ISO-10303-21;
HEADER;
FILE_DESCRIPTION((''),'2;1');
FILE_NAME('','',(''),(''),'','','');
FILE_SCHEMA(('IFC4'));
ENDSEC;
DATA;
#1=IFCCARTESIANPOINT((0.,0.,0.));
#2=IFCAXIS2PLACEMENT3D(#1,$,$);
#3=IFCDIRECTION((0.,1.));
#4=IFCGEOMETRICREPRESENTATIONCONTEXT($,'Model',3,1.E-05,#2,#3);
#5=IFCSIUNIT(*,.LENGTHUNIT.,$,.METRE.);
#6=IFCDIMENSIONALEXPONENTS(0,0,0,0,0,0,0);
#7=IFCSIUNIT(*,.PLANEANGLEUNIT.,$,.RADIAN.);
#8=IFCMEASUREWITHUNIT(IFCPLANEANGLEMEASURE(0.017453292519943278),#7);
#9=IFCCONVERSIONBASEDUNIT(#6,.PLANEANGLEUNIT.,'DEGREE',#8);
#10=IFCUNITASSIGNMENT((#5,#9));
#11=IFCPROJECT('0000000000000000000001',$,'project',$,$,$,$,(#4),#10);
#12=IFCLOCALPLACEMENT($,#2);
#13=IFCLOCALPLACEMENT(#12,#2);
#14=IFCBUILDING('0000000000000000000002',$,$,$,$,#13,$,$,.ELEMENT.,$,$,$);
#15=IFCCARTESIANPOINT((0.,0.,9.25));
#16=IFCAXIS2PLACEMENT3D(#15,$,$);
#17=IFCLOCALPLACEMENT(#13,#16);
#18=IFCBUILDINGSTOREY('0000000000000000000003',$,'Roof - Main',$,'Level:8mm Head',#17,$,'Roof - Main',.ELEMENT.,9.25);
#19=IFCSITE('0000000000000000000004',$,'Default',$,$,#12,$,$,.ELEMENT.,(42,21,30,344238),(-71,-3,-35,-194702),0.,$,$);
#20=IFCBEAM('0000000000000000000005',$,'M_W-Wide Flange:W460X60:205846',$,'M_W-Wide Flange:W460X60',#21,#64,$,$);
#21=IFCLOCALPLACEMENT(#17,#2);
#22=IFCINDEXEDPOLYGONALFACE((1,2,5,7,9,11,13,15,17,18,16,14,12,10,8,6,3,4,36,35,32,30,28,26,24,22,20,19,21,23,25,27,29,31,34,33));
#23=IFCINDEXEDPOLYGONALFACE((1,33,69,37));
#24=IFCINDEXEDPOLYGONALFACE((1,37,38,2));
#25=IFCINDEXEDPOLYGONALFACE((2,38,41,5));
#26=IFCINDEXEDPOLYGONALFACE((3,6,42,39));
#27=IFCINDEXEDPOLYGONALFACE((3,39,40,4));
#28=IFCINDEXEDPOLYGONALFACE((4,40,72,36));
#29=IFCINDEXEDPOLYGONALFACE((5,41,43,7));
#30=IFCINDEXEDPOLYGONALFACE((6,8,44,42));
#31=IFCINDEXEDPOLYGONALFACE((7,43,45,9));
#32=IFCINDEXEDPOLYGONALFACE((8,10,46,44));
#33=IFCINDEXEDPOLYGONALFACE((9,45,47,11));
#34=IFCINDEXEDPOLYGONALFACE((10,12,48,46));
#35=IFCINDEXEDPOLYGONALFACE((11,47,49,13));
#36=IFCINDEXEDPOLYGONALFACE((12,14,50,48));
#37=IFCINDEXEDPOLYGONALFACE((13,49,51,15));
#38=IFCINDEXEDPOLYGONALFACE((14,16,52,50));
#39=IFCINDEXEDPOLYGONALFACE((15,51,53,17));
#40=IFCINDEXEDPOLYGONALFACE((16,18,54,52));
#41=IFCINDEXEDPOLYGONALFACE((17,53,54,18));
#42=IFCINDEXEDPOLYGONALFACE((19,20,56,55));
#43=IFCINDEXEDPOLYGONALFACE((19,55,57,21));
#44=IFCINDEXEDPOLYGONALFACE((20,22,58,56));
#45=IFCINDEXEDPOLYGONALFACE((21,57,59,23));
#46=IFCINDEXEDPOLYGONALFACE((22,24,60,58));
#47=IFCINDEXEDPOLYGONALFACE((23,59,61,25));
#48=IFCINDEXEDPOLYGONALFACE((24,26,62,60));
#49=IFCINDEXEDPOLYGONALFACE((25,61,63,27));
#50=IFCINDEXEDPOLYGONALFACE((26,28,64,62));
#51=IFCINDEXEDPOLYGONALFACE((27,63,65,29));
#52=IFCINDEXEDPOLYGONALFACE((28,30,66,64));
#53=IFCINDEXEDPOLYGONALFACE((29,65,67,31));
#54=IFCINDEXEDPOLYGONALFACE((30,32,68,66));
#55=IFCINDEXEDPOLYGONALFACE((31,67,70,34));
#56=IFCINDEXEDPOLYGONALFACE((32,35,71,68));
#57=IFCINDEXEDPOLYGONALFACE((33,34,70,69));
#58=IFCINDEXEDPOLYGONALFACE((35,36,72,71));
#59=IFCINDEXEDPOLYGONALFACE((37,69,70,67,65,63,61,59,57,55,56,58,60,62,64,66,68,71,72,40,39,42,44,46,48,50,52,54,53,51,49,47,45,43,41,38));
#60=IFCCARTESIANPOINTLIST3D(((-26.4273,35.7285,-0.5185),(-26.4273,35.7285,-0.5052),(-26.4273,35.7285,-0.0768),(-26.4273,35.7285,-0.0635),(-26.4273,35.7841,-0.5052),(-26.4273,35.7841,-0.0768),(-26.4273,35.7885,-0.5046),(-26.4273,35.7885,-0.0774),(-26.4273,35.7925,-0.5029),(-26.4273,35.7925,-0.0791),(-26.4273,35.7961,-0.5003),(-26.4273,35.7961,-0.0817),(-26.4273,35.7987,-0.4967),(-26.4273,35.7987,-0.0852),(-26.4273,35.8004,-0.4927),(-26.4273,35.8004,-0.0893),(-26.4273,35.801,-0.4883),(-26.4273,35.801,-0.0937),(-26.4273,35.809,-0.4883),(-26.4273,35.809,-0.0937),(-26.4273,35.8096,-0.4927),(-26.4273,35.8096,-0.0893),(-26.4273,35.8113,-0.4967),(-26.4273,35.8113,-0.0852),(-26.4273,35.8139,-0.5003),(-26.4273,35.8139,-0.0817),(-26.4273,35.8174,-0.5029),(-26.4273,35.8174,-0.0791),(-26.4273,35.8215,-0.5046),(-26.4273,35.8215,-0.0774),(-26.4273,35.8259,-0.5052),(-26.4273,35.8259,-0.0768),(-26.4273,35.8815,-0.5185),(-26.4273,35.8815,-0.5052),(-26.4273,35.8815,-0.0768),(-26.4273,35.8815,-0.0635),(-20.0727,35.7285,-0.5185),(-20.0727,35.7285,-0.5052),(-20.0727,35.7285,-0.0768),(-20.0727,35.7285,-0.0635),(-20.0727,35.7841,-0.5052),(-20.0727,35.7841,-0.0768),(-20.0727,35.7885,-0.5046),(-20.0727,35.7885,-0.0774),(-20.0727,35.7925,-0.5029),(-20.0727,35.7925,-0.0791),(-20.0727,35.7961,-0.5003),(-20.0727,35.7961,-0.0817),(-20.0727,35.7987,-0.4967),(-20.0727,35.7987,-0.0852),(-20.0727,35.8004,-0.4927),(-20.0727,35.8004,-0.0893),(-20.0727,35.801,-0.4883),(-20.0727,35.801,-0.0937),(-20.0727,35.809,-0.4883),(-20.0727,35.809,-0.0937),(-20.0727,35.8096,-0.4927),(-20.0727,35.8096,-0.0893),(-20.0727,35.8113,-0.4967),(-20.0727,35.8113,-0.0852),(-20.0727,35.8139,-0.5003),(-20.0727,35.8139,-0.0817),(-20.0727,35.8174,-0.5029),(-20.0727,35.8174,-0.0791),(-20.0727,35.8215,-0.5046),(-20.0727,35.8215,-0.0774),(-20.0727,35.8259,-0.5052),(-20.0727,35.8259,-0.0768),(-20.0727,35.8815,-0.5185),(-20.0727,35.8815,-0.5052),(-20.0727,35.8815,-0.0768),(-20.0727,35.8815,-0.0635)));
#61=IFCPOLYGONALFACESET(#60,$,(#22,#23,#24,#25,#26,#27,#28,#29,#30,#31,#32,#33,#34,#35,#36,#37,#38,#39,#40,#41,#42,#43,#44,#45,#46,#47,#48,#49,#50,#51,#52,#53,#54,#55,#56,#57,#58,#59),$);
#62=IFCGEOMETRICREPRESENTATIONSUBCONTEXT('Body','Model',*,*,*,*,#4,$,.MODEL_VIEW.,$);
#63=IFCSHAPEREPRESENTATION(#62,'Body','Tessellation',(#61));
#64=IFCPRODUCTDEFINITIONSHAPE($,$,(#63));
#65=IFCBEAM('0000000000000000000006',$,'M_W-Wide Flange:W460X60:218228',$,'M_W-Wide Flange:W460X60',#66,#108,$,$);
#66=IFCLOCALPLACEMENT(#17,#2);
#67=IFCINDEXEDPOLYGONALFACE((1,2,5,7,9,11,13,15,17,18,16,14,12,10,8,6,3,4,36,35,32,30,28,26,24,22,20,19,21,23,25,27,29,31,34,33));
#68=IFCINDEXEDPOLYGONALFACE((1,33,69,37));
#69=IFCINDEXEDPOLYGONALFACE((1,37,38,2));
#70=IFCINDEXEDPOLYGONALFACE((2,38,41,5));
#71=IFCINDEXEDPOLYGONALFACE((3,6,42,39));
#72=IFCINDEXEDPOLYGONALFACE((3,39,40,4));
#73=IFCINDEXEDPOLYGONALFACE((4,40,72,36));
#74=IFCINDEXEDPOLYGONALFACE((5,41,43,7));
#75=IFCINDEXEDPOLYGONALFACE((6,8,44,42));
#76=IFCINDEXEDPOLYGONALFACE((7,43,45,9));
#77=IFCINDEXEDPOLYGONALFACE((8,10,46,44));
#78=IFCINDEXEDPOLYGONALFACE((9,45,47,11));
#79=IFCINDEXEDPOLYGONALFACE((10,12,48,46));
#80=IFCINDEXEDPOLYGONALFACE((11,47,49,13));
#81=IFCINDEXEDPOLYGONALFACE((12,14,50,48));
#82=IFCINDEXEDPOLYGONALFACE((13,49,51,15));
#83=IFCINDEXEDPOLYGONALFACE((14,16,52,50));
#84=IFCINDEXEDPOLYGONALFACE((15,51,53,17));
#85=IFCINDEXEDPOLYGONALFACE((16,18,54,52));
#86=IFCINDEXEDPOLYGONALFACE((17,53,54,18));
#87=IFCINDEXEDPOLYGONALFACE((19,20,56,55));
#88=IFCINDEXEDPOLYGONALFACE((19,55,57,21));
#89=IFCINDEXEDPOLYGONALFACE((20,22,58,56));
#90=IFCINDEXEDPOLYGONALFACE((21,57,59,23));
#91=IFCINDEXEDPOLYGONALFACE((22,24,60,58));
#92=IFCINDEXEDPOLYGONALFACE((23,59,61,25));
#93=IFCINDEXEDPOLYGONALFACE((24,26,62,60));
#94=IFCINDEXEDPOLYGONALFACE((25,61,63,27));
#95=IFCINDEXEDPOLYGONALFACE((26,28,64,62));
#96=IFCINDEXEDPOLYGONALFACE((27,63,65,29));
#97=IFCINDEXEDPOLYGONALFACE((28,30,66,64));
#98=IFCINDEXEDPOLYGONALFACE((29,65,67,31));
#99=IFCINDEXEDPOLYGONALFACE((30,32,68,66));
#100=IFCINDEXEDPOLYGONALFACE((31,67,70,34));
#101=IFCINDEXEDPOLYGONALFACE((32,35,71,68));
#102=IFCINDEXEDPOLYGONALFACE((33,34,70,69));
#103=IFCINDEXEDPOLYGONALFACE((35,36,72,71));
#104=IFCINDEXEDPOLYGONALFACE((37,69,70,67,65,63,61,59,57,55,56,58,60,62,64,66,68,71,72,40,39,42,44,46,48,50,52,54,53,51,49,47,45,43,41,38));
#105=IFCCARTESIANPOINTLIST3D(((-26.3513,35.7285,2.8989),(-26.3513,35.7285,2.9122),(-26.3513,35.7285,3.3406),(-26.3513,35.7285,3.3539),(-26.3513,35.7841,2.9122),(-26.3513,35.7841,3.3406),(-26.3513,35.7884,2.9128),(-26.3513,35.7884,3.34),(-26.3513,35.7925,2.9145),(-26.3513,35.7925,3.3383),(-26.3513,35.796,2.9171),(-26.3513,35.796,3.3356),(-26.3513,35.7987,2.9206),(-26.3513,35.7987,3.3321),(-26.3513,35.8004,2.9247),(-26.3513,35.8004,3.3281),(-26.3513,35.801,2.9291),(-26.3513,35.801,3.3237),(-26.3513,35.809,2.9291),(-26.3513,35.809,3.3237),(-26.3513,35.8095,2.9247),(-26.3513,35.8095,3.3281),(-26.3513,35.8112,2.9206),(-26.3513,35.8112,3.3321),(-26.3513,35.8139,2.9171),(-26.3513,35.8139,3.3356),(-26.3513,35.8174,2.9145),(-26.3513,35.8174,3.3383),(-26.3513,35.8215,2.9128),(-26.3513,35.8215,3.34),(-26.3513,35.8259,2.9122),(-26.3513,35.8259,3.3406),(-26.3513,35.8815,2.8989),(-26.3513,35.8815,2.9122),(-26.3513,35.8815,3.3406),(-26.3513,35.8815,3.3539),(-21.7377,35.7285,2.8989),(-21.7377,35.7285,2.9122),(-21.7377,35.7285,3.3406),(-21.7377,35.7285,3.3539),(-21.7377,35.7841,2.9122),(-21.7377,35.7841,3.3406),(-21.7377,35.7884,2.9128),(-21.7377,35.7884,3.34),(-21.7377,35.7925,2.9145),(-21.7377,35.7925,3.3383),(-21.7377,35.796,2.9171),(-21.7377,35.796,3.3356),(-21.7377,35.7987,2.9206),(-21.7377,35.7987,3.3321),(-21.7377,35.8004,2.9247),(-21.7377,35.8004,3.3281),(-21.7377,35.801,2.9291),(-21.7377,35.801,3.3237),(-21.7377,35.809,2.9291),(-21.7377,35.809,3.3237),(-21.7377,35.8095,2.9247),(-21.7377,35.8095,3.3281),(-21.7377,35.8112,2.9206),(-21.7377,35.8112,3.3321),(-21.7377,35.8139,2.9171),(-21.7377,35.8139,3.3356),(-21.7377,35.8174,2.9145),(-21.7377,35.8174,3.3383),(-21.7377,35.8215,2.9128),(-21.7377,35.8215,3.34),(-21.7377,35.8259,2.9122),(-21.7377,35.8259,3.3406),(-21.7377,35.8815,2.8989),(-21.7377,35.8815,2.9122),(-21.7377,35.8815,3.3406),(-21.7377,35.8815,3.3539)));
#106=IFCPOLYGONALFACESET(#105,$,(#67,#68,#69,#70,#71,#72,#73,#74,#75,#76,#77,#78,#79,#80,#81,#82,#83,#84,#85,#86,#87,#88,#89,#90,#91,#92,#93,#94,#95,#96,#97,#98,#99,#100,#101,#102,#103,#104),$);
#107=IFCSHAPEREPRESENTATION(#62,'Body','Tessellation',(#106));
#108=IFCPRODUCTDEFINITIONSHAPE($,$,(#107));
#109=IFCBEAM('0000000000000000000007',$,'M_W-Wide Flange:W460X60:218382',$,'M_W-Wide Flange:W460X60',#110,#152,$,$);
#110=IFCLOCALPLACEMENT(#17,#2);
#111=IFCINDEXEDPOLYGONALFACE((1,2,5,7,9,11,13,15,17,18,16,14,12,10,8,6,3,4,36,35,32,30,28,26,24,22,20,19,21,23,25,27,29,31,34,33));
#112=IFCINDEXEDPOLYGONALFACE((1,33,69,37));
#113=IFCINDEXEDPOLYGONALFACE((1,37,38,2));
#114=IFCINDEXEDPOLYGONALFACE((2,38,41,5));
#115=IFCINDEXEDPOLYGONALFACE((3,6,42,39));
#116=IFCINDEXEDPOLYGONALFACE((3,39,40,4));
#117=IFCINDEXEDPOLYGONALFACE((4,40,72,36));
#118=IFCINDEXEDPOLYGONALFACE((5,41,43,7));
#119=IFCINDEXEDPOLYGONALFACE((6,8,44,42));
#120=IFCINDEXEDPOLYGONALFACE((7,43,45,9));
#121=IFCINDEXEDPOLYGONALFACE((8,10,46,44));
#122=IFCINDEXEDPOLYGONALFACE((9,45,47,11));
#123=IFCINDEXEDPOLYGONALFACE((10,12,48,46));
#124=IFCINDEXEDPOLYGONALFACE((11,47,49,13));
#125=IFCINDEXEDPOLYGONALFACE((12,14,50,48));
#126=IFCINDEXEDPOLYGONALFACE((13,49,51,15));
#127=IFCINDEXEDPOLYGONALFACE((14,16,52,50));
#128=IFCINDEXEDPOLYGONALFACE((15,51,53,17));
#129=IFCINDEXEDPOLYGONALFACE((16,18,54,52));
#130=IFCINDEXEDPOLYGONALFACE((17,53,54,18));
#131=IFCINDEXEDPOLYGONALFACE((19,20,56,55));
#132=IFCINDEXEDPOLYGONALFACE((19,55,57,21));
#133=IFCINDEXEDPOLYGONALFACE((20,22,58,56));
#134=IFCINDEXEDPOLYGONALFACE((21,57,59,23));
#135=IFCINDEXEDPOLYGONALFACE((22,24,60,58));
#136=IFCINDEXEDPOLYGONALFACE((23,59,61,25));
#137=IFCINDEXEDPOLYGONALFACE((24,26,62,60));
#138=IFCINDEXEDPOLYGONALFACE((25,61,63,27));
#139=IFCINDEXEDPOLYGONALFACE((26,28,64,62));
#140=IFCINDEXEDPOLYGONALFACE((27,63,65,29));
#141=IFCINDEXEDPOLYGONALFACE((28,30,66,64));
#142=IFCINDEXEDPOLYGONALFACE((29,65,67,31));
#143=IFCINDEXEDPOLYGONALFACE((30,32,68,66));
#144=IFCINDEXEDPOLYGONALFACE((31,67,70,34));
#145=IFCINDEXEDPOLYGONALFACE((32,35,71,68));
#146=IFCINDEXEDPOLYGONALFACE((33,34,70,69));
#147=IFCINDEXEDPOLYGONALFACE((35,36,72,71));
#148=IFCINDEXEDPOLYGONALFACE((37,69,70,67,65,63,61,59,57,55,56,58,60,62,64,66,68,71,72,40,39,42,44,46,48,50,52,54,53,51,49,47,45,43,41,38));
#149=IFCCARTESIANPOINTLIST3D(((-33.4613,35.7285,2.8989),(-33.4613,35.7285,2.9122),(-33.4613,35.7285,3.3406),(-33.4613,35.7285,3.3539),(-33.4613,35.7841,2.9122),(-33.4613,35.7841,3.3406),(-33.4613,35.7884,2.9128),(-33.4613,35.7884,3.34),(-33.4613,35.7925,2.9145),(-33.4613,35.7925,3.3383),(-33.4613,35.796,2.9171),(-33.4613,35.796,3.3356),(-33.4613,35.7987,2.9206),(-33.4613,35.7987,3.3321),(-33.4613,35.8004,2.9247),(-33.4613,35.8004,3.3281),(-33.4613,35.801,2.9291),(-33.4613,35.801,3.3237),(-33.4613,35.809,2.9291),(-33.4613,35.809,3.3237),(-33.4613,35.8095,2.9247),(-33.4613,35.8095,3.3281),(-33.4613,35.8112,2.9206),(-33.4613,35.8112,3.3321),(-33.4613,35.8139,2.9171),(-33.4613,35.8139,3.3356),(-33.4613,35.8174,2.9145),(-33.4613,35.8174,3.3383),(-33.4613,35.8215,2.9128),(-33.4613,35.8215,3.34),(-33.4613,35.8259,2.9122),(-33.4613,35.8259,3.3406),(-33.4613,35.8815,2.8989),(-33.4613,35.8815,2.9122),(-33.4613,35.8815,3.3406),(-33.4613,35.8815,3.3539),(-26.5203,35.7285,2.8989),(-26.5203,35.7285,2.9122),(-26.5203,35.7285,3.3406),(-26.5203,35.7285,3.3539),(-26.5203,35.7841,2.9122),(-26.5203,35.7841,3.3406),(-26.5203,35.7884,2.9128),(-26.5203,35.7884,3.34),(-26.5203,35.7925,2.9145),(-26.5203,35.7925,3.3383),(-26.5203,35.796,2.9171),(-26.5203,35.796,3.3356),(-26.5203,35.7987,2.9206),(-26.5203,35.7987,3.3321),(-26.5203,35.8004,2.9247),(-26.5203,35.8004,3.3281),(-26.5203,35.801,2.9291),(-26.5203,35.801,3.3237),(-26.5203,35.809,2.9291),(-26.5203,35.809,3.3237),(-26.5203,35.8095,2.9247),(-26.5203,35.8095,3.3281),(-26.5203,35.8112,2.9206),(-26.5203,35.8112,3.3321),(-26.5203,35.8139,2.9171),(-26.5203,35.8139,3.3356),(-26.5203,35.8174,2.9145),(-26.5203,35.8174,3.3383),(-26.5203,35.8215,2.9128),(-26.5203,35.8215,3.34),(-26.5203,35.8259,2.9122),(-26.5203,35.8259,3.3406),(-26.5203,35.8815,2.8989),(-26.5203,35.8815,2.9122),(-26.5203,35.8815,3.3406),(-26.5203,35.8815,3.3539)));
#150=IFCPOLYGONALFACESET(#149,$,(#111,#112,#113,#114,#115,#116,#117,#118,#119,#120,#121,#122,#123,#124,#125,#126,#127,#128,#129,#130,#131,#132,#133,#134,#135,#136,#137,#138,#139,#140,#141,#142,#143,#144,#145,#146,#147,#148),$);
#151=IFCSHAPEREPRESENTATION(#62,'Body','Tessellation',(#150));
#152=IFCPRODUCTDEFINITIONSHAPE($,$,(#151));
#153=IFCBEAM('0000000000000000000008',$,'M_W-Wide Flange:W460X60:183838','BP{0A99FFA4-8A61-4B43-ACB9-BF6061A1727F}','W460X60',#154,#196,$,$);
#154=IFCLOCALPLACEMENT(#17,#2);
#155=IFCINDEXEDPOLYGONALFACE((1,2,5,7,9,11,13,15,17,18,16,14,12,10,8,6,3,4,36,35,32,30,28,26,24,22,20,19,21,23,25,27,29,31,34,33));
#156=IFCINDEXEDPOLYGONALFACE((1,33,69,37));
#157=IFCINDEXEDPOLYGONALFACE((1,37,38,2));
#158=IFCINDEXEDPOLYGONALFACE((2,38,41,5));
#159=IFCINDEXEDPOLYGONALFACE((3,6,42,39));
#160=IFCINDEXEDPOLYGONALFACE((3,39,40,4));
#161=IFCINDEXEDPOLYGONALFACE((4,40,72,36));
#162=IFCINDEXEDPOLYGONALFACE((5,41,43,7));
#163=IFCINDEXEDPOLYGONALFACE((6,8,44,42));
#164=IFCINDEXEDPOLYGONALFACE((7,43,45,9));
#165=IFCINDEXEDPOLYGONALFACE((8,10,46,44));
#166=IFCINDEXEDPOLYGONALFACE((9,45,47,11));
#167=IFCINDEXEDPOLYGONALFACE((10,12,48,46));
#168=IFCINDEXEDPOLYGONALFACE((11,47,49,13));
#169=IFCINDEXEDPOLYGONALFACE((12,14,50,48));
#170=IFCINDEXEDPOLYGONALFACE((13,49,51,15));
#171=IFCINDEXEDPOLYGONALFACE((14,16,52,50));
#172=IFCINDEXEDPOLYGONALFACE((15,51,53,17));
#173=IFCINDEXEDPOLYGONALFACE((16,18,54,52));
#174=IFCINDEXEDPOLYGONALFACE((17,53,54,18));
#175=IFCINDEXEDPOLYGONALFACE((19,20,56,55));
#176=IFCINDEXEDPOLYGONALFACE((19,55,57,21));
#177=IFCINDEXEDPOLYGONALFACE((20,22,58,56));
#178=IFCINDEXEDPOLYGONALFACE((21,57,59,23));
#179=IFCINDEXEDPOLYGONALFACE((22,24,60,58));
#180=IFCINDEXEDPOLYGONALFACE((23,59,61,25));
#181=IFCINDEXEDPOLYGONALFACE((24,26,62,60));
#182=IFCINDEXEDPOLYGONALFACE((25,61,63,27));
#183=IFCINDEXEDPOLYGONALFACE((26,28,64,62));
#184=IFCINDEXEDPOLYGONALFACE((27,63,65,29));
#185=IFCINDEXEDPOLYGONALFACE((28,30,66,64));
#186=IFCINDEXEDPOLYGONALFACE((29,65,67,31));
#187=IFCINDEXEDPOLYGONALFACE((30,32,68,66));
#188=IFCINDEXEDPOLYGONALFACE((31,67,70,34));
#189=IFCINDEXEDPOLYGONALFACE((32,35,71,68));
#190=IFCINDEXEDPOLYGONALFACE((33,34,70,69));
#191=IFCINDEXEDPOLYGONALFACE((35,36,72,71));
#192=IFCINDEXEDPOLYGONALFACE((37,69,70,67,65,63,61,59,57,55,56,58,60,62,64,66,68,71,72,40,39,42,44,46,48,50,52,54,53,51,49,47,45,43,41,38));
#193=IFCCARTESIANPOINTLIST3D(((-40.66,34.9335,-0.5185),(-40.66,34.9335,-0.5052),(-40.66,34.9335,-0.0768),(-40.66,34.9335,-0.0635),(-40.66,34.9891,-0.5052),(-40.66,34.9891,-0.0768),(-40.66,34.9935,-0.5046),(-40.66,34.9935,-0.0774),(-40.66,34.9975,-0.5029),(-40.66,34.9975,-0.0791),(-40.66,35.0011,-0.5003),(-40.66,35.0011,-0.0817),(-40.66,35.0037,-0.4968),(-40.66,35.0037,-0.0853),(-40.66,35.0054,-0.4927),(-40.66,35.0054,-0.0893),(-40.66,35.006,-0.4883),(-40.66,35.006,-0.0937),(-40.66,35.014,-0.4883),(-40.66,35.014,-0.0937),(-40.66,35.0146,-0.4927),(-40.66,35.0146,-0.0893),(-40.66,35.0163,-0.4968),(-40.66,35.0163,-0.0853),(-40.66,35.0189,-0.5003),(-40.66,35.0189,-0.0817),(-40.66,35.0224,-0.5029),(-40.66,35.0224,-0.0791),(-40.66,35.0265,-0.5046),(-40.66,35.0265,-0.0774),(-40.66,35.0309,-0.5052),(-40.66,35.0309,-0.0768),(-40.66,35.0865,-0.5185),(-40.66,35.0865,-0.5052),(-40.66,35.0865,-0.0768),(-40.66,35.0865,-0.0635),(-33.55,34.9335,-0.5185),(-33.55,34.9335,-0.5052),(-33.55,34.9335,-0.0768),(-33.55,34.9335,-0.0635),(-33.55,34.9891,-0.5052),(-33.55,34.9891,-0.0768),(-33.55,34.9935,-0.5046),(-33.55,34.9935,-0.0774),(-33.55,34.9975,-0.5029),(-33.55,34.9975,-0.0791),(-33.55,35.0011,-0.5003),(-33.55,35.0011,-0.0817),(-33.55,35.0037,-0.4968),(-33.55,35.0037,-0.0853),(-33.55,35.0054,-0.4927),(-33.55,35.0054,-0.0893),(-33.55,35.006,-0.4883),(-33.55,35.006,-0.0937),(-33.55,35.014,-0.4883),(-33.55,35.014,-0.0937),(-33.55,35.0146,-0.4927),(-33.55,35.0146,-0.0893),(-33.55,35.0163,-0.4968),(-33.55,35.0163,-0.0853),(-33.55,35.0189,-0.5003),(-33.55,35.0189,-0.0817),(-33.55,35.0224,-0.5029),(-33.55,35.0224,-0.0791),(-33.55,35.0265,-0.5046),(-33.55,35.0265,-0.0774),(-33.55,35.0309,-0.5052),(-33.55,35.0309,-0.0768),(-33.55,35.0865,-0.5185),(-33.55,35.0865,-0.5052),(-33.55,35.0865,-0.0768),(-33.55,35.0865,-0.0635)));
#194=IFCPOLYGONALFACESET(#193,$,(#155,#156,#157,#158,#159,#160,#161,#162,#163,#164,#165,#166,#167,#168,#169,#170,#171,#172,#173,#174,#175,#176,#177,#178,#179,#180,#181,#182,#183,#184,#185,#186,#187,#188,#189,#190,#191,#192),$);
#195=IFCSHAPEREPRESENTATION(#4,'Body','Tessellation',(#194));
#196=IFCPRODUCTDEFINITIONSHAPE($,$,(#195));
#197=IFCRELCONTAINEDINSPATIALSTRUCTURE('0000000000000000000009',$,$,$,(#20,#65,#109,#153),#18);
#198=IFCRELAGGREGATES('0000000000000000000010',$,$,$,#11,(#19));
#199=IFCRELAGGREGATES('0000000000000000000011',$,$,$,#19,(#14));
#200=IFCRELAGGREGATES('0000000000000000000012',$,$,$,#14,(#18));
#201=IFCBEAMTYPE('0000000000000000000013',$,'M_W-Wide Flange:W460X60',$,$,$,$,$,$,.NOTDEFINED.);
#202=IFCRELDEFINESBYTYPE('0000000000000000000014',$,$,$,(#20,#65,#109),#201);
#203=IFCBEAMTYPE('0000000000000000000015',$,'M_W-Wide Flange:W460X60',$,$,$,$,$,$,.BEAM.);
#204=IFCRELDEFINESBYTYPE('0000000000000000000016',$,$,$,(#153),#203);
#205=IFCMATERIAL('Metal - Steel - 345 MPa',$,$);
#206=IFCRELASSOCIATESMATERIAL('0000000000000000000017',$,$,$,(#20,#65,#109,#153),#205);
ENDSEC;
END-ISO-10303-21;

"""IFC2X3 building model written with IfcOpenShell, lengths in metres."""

from ifc_helpers import new_model, entity, si_unit, converted_unit, direction, frame, frame_2d, origin, origin_2d, place, context, subcontext, project, spatial, i_section, extrude, material, type_object, element, save


model = new_model("IFC2X3")

# Units and contexts
model_context = context("Model", 3, precision=1e-05, world=origin(), true_north=direction((0.0, 1.0)))
body_context = subcontext(model_context, "Body", "Model", "MODEL_VIEW")
ifc_project = project(units=[si_unit("LENGTHUNIT", "METRE"), converted_unit("PLANEANGLEUNIT", "DEGREE", entity("IfcPlaneAngleMeasure", 0.017453292519943278), si_unit("PLANEANGLEUNIT", "RADIAN"), dimensions=[0, 0, 0, 0, 0, 0, 0])], contexts=[model_context])

# Site, building, storey
site_placement = place(None, origin())
site = spatial("IfcSite", under=ifc_project, at=site_placement, Name="Default", CompositionType="ELEMENT", RefLatitude=(42, 21, 30, 344238), RefLongitude=(-71, -3, -35, -194702), RefElevation=0.0)
building_placement = place(site_placement, origin())
building = spatial("IfcBuilding", under=site, at=building_placement, CompositionType="ELEMENT")
storey_placement = place(building_placement, frame((0.0, 0.0, 9.25)))
storey = spatial("IfcBuildingStorey", under=building, at=storey_placement, Name="Roof - Main", ObjectType="Level:8mm Head", LongName="Roof - Main", CompositionType="ELEMENT", Elevation=9.25)

# Shared definitions
ifc_material_1 = material(Name="Metal - Steel - 345 MPa")

# Beams
beam_type_1 = type_object("IfcBeamType", Name="M_W-Wide Flange:W460X60", PredefinedType="NOTDEFINED")
beam_1_placement = place(storey_placement, frame((-26.44, 35.805, -0.0635)))
element("IfcBeam", 1, at=beam_1_placement, inside=storey, type_object=beam_type_1, material=ifc_material_1, Name="M_W-Wide Flange:W460X60:205846", ObjectType="M_W-Wide Flange:W460X60", context=body_context, shape_type="SweptSolid", body=[
    extrude(i_section(OverallWidth=0.153, OverallDepth=0.455, WebThickness=0.008, FlangeThickness=0.0133, FilletRadius=0.0169, at=frame_2d((0.0, 0.0), x_axis=(0.0, 1.0))), frame((0.0127, 0.0, -0.2275), z_axis=(1.0, 0.0, 0.0), x_axis=(0.0, 0.0, -1.0)), (0.0, 0.0, 1.0), 6.3546),
])
beam_2_placement = place(storey_placement, frame((-26.44, 35.805, 3.3539)))
element("IfcBeam", 2, at=beam_2_placement, inside=storey, type_object=beam_type_1, material=ifc_material_1, Name="M_W-Wide Flange:W460X60:218228", ObjectType="M_W-Wide Flange:W460X60", context=body_context, shape_type="SweptSolid", body=[
    extrude(i_section(OverallWidth=0.153, OverallDepth=0.455, WebThickness=0.008, FlangeThickness=0.0133, FilletRadius=0.0169, at=frame_2d((0.0, 0.0), x_axis=(0.0, 1.0))), frame((0.0887, 0.0, -0.2275), z_axis=(1.0, 0.0, 0.0), x_axis=(0.0, 0.0, -1.0)), (0.0, 0.0, 1.0), 4.6136),
])
beam_3_placement = place(storey_placement, frame((-33.56, 35.805, 3.3539)))
element("IfcBeam", 3, at=beam_3_placement, inside=storey, type_object=beam_type_1, material=ifc_material_1, Name="M_W-Wide Flange:W460X60:218382", ObjectType="M_W-Wide Flange:W460X60", context=body_context, shape_type="SweptSolid", body=[
    extrude(i_section(OverallWidth=0.153, OverallDepth=0.455, WebThickness=0.008, FlangeThickness=0.0133, FilletRadius=0.0169, at=frame_2d((0.0, 0.0), x_axis=(0.0, 1.0))), frame((0.0987, 0.0, -0.2275), z_axis=(1.0, 0.0, 0.0), x_axis=(0.0, 0.0, -1.0)), (0.0, 0.0, 1.0), 6.941),
])

# Beam
beam_type_2 = type_object("IfcBeamType", Name="M_W-Wide Flange:W460X60", PredefinedType="BEAM")
beam_4_placement = place(storey_placement, frame((-33.55, 35.01, -0.291), z_axis=(1.0, 0.0, 0.0), x_axis=(0.0, 1.0, 0.0)))
element("IfcBeam", 4, at=beam_4_placement, inside=storey, type_object=beam_type_2, material=ifc_material_1, Name="M_W-Wide Flange:W460X60:183838", Description="BP{0A99FFA4-8A61-4B43-ACB9-BF6061A1727F}", ObjectType="W460X60", context=model_context, shape_type="SweptSolid", body=[
    extrude(i_section(OverallWidth=0.153, OverallDepth=0.455, WebThickness=0.008, FlangeThickness=0.0133, FilletRadius=0.0169, at=origin_2d()), origin(), (0.0, 0.0, -1.0), 7.11),
])

save(model, "model.ifc")
